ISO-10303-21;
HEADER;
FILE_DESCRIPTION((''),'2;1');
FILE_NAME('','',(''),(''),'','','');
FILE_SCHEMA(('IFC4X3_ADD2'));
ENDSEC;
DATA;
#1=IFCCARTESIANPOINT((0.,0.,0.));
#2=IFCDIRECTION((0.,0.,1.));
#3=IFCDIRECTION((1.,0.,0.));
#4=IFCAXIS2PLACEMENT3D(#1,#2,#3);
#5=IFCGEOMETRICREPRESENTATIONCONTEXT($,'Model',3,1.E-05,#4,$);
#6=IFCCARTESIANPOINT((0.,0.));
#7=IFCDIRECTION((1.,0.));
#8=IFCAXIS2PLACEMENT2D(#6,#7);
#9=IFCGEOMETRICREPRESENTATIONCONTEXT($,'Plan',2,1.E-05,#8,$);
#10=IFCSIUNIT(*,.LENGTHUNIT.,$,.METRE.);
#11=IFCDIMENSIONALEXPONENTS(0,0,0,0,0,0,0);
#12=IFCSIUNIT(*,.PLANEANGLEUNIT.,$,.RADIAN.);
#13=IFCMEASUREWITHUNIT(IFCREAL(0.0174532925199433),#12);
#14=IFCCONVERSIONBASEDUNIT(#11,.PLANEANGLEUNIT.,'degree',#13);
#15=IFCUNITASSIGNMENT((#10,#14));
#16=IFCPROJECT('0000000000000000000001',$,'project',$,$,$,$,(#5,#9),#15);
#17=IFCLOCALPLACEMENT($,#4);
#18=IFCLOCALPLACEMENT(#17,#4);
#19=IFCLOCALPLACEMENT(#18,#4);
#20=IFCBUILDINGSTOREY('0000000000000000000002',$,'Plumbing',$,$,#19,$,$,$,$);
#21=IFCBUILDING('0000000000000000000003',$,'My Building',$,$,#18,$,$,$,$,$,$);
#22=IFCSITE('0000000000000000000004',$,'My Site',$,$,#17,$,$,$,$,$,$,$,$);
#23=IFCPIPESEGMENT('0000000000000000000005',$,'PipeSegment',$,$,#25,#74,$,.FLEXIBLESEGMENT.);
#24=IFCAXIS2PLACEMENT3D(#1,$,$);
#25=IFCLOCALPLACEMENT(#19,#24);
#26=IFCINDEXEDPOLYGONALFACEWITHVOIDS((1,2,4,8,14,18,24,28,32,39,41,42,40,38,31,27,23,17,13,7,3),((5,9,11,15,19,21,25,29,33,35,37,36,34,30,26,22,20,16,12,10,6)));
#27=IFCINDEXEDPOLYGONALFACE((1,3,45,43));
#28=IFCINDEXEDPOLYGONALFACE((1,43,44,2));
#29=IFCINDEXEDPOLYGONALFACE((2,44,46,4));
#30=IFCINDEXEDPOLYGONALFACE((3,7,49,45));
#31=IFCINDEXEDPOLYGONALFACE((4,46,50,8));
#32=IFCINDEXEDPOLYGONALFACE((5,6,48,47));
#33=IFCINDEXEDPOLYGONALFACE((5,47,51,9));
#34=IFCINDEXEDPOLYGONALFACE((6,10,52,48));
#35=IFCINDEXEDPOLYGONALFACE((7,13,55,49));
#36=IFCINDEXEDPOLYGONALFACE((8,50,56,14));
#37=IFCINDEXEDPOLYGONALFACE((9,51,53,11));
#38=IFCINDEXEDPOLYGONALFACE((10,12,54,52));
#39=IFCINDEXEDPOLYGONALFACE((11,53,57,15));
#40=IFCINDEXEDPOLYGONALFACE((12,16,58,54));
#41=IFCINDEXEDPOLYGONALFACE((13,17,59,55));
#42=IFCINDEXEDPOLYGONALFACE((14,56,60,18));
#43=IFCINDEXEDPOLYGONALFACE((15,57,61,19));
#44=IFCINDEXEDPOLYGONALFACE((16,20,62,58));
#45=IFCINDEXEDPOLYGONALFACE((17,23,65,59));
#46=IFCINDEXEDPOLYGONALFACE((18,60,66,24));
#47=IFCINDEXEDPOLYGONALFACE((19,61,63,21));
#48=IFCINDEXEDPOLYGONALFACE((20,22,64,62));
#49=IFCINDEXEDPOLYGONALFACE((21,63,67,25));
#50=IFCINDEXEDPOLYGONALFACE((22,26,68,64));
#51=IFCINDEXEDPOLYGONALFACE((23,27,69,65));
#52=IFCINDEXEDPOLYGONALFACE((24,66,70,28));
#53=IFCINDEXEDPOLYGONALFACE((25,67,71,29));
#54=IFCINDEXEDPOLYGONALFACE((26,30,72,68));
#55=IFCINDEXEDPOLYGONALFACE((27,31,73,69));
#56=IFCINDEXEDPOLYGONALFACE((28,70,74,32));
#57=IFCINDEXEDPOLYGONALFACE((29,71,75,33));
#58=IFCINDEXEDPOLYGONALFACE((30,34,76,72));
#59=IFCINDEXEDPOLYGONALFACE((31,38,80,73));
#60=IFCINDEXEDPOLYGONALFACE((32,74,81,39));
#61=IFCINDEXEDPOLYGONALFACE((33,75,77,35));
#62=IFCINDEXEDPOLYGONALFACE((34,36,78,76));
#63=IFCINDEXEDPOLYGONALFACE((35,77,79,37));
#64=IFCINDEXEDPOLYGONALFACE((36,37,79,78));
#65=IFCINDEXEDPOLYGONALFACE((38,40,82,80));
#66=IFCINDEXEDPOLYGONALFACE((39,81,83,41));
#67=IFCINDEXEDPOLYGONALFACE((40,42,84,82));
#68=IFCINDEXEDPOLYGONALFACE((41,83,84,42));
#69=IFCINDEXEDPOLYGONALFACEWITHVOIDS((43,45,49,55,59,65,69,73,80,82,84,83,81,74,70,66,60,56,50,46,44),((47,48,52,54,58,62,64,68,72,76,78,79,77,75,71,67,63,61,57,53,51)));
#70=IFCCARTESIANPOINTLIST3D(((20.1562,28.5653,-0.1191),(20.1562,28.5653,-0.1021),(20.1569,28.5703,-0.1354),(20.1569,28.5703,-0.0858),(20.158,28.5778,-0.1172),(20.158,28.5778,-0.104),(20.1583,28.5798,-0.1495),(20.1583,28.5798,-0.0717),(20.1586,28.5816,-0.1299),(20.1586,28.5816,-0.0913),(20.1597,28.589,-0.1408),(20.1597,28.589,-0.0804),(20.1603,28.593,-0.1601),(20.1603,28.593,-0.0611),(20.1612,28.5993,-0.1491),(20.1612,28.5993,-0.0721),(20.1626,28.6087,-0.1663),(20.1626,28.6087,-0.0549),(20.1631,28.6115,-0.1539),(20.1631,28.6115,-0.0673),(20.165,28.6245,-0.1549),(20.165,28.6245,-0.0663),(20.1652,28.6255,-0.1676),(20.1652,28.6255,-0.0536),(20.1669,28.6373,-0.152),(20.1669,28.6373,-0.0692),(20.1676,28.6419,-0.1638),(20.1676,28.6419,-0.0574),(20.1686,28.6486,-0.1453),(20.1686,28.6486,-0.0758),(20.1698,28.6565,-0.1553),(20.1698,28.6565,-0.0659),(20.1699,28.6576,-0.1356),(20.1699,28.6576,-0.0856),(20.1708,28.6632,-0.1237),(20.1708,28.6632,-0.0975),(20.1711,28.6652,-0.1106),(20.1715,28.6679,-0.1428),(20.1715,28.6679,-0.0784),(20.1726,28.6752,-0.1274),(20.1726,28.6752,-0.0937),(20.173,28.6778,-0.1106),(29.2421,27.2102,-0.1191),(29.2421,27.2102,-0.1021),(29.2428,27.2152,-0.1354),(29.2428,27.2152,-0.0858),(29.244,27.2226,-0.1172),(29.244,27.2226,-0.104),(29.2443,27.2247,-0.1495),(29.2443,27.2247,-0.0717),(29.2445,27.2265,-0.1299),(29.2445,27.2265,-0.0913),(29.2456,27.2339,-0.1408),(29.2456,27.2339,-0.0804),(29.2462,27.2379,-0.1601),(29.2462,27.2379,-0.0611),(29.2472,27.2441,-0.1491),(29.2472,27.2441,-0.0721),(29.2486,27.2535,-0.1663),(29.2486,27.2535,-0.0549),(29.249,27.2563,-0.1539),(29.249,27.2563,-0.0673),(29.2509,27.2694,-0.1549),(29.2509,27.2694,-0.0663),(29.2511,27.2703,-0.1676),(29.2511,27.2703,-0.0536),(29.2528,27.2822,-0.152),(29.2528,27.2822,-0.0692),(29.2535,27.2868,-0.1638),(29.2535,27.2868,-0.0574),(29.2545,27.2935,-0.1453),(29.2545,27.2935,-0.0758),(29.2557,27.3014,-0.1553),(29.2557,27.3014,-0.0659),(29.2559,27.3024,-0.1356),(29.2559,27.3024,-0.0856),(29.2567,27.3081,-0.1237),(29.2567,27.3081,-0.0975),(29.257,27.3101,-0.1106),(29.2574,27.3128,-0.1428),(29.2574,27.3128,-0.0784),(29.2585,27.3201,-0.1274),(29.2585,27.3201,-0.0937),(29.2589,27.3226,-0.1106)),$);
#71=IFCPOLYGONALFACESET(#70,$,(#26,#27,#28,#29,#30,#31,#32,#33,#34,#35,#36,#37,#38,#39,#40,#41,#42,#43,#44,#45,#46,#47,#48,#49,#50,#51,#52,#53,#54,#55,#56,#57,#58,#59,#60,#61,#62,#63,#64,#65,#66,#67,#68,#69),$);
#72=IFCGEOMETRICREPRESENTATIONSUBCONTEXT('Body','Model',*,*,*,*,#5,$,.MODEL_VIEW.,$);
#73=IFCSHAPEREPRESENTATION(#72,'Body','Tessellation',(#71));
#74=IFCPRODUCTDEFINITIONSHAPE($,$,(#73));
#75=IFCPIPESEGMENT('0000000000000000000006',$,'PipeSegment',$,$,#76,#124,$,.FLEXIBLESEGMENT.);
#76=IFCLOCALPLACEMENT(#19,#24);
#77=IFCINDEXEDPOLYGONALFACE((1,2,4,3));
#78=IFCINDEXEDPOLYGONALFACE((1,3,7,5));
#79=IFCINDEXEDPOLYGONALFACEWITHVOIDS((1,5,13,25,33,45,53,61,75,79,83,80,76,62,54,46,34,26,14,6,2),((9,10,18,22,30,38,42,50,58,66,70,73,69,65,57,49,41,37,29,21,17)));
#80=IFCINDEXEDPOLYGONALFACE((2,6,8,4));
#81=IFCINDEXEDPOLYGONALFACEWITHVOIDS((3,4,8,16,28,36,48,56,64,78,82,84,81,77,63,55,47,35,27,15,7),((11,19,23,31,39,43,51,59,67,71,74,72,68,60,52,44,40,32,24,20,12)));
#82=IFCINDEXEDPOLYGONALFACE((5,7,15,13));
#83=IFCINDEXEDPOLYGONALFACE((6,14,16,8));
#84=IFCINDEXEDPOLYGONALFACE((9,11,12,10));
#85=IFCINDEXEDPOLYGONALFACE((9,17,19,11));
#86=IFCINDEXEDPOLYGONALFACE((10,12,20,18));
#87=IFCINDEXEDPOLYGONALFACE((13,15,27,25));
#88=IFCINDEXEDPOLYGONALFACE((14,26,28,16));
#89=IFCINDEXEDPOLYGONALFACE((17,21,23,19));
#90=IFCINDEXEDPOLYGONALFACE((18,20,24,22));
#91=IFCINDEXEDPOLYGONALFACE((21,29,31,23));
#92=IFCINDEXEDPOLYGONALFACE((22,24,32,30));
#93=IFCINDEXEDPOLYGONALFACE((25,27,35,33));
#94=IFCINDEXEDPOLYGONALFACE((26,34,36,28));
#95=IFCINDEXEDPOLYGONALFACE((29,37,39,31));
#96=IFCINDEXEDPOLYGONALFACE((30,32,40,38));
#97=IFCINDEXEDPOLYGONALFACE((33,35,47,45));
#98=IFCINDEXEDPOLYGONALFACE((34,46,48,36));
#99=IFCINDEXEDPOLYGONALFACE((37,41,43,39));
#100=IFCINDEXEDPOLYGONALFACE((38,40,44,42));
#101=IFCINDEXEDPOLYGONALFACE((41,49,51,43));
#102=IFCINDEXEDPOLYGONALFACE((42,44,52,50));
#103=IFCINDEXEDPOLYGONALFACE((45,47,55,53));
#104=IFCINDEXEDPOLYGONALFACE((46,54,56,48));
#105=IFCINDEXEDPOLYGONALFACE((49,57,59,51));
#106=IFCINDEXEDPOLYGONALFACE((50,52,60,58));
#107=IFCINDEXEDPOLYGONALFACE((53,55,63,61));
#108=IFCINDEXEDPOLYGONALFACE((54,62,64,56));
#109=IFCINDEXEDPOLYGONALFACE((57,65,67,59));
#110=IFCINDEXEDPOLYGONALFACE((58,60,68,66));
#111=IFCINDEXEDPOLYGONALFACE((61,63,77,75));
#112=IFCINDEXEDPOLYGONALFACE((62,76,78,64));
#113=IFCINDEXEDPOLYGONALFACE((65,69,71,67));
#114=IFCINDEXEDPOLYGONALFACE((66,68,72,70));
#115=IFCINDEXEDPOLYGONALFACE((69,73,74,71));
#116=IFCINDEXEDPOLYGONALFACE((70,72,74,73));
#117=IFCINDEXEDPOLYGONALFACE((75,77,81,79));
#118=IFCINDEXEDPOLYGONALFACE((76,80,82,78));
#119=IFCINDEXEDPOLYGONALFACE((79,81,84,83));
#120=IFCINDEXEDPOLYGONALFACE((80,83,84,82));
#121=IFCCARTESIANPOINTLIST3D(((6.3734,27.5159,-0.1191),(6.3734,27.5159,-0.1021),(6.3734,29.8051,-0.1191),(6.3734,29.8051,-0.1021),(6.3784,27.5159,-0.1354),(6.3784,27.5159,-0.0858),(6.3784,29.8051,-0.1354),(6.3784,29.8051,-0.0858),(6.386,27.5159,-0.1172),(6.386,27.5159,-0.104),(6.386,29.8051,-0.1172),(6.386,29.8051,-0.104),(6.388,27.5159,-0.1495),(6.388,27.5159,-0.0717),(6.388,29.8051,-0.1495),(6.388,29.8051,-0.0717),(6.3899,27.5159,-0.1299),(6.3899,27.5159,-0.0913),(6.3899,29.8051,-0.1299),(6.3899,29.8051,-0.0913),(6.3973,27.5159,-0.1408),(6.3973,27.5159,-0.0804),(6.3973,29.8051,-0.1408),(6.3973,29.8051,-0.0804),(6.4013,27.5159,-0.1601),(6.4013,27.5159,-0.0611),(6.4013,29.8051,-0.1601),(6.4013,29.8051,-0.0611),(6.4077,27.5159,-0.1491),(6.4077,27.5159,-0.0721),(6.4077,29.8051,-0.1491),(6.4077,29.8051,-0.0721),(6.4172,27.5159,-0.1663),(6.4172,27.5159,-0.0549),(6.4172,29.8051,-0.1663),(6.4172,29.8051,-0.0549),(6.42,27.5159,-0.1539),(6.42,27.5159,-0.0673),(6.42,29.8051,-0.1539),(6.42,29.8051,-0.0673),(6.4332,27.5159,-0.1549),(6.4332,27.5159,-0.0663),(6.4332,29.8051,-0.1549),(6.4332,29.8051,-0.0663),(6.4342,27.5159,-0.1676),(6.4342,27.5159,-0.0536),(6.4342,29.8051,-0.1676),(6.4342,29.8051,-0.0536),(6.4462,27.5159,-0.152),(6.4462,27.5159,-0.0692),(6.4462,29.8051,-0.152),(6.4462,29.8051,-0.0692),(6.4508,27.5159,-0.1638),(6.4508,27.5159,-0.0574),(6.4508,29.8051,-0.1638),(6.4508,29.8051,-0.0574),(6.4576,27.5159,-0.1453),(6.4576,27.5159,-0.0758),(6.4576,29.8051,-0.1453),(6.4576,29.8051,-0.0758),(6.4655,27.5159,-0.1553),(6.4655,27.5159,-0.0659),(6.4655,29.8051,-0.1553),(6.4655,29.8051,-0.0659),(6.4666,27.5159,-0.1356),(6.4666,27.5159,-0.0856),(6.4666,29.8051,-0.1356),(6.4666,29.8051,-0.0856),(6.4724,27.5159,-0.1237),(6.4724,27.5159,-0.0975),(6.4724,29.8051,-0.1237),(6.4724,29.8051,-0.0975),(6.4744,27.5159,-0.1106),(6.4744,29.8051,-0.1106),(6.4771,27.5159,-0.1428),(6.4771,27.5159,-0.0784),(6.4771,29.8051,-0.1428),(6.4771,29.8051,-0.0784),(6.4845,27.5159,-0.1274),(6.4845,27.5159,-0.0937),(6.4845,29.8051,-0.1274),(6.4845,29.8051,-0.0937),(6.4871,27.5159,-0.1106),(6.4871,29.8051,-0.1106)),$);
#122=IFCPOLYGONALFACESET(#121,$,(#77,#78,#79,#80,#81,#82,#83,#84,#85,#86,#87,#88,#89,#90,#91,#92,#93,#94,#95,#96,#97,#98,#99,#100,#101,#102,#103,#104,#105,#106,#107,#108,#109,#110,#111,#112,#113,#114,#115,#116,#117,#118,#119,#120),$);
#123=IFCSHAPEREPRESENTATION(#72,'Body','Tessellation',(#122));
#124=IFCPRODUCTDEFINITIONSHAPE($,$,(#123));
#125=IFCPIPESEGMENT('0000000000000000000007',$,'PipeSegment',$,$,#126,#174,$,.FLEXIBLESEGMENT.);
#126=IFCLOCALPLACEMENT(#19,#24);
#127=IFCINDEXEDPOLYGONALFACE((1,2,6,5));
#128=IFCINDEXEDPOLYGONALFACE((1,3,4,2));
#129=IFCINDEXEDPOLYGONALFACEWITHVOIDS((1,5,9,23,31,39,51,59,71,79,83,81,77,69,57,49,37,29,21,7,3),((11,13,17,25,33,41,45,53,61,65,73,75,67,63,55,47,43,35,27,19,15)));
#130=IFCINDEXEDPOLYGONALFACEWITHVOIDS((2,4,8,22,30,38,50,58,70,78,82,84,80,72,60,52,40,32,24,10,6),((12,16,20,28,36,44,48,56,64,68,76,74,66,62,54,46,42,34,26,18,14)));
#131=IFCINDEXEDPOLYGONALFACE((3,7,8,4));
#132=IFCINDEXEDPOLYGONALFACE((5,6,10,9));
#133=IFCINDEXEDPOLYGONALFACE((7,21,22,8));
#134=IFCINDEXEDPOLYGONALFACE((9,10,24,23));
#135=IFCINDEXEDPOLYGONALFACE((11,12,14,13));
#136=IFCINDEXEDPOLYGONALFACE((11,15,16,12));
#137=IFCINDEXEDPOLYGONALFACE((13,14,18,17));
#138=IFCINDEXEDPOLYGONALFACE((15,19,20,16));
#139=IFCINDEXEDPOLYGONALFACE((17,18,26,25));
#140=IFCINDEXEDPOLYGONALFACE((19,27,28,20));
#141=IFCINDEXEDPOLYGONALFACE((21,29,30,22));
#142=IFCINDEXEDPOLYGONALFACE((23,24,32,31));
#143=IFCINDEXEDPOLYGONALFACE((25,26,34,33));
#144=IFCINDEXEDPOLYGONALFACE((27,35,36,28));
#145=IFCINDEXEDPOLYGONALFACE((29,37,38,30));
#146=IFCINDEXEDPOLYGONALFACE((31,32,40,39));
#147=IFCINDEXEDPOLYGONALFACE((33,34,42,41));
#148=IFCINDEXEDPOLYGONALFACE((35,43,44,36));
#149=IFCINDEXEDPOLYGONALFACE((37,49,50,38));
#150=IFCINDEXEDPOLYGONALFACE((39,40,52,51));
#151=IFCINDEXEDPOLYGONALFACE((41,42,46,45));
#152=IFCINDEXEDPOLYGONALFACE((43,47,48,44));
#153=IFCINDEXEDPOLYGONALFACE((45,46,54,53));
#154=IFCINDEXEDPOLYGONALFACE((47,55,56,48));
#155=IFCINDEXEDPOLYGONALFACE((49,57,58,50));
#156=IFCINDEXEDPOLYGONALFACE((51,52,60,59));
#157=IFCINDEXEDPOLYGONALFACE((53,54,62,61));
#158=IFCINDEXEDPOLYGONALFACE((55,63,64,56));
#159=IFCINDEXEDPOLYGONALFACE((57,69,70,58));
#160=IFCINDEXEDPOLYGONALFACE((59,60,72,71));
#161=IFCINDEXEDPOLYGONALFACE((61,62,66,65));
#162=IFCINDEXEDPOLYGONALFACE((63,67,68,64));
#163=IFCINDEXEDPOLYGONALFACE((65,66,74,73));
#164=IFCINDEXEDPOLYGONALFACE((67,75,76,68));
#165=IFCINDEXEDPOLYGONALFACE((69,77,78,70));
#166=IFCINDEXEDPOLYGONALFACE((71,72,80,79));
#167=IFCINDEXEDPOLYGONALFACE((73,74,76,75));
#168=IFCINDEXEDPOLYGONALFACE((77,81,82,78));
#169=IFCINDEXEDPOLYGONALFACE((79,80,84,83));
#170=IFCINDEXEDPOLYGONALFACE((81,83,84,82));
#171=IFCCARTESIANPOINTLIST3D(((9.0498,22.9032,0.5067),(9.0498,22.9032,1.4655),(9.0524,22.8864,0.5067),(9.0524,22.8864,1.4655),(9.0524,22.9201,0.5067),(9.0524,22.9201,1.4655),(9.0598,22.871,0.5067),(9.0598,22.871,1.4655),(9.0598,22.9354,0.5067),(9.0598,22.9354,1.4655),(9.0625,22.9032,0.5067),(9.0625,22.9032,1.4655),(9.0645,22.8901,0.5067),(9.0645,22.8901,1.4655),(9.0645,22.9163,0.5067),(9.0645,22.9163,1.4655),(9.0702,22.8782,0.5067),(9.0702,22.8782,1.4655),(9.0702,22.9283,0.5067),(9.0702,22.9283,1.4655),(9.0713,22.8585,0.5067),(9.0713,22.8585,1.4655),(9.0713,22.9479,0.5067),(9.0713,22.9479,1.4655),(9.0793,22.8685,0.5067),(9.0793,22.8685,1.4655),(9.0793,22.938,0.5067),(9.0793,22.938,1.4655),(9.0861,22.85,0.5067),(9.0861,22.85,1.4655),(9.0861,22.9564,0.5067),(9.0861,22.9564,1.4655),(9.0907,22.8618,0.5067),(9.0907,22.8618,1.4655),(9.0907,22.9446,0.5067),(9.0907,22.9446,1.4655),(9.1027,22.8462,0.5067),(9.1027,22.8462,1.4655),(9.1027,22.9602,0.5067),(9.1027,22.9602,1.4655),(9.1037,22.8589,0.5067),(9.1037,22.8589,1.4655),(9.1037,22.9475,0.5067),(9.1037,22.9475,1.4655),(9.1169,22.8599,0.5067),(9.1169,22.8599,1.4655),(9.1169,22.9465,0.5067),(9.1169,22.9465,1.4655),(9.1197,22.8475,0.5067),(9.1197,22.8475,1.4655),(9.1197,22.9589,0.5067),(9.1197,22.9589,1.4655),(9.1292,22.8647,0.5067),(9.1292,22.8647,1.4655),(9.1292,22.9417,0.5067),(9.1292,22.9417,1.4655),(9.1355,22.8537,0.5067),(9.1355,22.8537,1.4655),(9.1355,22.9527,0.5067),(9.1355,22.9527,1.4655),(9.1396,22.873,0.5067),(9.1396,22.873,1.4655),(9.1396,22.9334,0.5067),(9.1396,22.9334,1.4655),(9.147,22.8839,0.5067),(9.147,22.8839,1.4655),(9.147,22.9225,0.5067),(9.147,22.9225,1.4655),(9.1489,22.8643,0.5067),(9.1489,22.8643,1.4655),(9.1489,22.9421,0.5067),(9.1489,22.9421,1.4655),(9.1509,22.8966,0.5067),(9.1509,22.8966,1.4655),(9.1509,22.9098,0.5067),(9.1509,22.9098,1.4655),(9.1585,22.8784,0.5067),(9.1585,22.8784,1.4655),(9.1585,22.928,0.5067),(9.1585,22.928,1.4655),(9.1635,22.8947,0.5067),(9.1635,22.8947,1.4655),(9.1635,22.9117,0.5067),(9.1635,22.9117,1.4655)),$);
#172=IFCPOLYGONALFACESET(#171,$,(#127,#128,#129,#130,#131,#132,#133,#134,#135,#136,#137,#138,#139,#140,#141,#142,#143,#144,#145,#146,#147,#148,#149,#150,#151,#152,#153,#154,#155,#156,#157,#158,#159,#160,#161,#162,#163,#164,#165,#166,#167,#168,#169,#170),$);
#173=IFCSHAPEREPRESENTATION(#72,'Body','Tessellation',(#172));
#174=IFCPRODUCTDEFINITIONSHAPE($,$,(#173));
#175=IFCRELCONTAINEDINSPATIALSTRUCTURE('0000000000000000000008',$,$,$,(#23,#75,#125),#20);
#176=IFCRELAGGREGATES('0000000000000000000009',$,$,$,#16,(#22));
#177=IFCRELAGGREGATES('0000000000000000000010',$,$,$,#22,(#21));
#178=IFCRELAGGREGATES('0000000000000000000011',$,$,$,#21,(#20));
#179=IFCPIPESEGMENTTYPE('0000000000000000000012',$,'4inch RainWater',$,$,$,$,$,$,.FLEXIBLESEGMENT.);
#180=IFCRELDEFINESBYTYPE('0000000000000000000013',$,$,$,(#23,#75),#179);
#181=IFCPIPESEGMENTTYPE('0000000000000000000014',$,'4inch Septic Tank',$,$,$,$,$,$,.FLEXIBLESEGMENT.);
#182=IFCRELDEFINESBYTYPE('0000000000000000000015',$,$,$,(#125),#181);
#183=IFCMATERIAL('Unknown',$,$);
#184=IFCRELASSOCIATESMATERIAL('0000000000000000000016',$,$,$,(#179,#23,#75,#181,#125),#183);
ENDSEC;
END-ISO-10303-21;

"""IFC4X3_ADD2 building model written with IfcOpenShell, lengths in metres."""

from ifc_helpers import new_model, entity, si_unit, converted_unit, frame, origin_with_axes, origin_2d_with_axis, place, context, subcontext, project, spatial, hollow_circle, extrude, material, material_profile, profile_set, profile_usage, type_object, element, save


model = new_model("IFC4X3_ADD2")

# Units and contexts
model_context = context("Model", 3, precision=1e-05, world=origin_with_axes())
plan_context = context("Plan", 2, precision=1e-05, world=origin_2d_with_axis())
body_context = subcontext(model_context, "Body", "Model", "MODEL_VIEW")
ifc_project = project(units=[si_unit("LENGTHUNIT", "METRE"), converted_unit("PLANEANGLEUNIT", "degree", entity("IfcReal", 0.0174532925199433), si_unit("PLANEANGLEUNIT", "RADIAN"), dimensions=[0, 0, 0, 0, 0, 0, 0])], contexts=[model_context, plan_context])

# Site, building, storey
site_placement = place(None, origin_with_axes())
site = spatial("IfcSite", under=ifc_project, at=site_placement, Name="My Site")
building_placement = place(site_placement, origin_with_axes())
building = spatial("IfcBuilding", under=site, at=building_placement, Name="My Building")
storey_placement = place(building_placement, origin_with_axes())
storey = spatial("IfcBuildingStorey", under=building, at=storey_placement, Name="Plumbing")

# Pipe segments
ifc_material_1 = material(Name="Unknown")
ifc_material_profile_1 = material_profile(ifc_material_1, hollow_circle(Radius=0.0571, WallThickness=0.0127))
ifc_profile_set_1 = profile_set([ifc_material_profile_1], Name="rainwater")
pipe_segment_type_1 = type_object("IfcPipeSegmentType", Name="4inch RainWater", PredefinedType="FLEXIBLESEGMENT", material=ifc_profile_set_1)
ifc_profile_usage_1 = profile_usage(ifc_profile_set_1)
pipe_segment_1_placement = place(storey_placement, frame((29.2504, 27.2661, -0.1106), z_axis=(-0.98906, 0.147513, 0.0), x_axis=(0.147513, 0.98906, -0.000001)))
element("IfcPipeSegment", 1, at=pipe_segment_1_placement, inside=storey, type_object=pipe_segment_type_1, material=ifc_profile_usage_1, Name="PipeSegment", PredefinedType="FLEXIBLESEGMENT", context=body_context, shape_type="SweptSolid", body=[
    extrude(hollow_circle(Radius=0.0571, WallThickness=0.0127), origin_with_axes(), (0.0, 0.0, 1.0), 9.1864),
])
ifc_profile_usage_2 = profile_usage(ifc_profile_set_1)
pipe_segment_2_placement = place(storey_placement, frame((6.4299, 27.5159, -0.1106), z_axis=(0.0, 1.0, 0.0), x_axis=(1.0, 0.0, -0.000001)))
element("IfcPipeSegment", 2, at=pipe_segment_2_placement, inside=storey, type_object=pipe_segment_type_1, material=ifc_profile_usage_2, Name="PipeSegment", PredefinedType="FLEXIBLESEGMENT", context=body_context, shape_type="SweptSolid", body=[
    extrude(hollow_circle(Radius=0.0571, WallThickness=0.0127), origin_with_axes(), (0.0, 0.0, 1.0), 2.2892),
])
ifc_material_profile_2 = material_profile(ifc_material_1, hollow_circle(Radius=0.0571, WallThickness=0.0127))
ifc_profile_set_2 = profile_set([ifc_material_profile_2], Name="blackwater")
ifc_profile_usage_3 = profile_usage(ifc_profile_set_2, cardinal=5)
ifc_material_profile_3 = material_profile(ifc_material_1, hollow_circle(Radius=0.0571, WallThickness=0.0127))
ifc_profile_set_3 = profile_set([ifc_material_profile_3], Name="blackwater")
pipe_segment_type_2 = type_object("IfcPipeSegmentType", Name="4inch Septic Tank", PredefinedType="FLEXIBLESEGMENT", material=ifc_profile_set_3)
pipe_segment_3_placement = place(storey_placement, frame((9.107, 22.9032, 0.5067), z_axis=(0.0, 0.0, 1.0), x_axis=(-1.0, -0.000001, 0.0)))
element("IfcPipeSegment", 3, at=pipe_segment_3_placement, inside=storey, type_object=pipe_segment_type_2, material=ifc_profile_usage_3, Name="PipeSegment", PredefinedType="FLEXIBLESEGMENT", context=body_context, shape_type="SweptSolid", body=[
    extrude(hollow_circle(Radius=0.0571, WallThickness=0.0127), origin_with_axes(), (0.0, 0.0, 1.0), 0.9588),
])

save(model, "model.ifc")
